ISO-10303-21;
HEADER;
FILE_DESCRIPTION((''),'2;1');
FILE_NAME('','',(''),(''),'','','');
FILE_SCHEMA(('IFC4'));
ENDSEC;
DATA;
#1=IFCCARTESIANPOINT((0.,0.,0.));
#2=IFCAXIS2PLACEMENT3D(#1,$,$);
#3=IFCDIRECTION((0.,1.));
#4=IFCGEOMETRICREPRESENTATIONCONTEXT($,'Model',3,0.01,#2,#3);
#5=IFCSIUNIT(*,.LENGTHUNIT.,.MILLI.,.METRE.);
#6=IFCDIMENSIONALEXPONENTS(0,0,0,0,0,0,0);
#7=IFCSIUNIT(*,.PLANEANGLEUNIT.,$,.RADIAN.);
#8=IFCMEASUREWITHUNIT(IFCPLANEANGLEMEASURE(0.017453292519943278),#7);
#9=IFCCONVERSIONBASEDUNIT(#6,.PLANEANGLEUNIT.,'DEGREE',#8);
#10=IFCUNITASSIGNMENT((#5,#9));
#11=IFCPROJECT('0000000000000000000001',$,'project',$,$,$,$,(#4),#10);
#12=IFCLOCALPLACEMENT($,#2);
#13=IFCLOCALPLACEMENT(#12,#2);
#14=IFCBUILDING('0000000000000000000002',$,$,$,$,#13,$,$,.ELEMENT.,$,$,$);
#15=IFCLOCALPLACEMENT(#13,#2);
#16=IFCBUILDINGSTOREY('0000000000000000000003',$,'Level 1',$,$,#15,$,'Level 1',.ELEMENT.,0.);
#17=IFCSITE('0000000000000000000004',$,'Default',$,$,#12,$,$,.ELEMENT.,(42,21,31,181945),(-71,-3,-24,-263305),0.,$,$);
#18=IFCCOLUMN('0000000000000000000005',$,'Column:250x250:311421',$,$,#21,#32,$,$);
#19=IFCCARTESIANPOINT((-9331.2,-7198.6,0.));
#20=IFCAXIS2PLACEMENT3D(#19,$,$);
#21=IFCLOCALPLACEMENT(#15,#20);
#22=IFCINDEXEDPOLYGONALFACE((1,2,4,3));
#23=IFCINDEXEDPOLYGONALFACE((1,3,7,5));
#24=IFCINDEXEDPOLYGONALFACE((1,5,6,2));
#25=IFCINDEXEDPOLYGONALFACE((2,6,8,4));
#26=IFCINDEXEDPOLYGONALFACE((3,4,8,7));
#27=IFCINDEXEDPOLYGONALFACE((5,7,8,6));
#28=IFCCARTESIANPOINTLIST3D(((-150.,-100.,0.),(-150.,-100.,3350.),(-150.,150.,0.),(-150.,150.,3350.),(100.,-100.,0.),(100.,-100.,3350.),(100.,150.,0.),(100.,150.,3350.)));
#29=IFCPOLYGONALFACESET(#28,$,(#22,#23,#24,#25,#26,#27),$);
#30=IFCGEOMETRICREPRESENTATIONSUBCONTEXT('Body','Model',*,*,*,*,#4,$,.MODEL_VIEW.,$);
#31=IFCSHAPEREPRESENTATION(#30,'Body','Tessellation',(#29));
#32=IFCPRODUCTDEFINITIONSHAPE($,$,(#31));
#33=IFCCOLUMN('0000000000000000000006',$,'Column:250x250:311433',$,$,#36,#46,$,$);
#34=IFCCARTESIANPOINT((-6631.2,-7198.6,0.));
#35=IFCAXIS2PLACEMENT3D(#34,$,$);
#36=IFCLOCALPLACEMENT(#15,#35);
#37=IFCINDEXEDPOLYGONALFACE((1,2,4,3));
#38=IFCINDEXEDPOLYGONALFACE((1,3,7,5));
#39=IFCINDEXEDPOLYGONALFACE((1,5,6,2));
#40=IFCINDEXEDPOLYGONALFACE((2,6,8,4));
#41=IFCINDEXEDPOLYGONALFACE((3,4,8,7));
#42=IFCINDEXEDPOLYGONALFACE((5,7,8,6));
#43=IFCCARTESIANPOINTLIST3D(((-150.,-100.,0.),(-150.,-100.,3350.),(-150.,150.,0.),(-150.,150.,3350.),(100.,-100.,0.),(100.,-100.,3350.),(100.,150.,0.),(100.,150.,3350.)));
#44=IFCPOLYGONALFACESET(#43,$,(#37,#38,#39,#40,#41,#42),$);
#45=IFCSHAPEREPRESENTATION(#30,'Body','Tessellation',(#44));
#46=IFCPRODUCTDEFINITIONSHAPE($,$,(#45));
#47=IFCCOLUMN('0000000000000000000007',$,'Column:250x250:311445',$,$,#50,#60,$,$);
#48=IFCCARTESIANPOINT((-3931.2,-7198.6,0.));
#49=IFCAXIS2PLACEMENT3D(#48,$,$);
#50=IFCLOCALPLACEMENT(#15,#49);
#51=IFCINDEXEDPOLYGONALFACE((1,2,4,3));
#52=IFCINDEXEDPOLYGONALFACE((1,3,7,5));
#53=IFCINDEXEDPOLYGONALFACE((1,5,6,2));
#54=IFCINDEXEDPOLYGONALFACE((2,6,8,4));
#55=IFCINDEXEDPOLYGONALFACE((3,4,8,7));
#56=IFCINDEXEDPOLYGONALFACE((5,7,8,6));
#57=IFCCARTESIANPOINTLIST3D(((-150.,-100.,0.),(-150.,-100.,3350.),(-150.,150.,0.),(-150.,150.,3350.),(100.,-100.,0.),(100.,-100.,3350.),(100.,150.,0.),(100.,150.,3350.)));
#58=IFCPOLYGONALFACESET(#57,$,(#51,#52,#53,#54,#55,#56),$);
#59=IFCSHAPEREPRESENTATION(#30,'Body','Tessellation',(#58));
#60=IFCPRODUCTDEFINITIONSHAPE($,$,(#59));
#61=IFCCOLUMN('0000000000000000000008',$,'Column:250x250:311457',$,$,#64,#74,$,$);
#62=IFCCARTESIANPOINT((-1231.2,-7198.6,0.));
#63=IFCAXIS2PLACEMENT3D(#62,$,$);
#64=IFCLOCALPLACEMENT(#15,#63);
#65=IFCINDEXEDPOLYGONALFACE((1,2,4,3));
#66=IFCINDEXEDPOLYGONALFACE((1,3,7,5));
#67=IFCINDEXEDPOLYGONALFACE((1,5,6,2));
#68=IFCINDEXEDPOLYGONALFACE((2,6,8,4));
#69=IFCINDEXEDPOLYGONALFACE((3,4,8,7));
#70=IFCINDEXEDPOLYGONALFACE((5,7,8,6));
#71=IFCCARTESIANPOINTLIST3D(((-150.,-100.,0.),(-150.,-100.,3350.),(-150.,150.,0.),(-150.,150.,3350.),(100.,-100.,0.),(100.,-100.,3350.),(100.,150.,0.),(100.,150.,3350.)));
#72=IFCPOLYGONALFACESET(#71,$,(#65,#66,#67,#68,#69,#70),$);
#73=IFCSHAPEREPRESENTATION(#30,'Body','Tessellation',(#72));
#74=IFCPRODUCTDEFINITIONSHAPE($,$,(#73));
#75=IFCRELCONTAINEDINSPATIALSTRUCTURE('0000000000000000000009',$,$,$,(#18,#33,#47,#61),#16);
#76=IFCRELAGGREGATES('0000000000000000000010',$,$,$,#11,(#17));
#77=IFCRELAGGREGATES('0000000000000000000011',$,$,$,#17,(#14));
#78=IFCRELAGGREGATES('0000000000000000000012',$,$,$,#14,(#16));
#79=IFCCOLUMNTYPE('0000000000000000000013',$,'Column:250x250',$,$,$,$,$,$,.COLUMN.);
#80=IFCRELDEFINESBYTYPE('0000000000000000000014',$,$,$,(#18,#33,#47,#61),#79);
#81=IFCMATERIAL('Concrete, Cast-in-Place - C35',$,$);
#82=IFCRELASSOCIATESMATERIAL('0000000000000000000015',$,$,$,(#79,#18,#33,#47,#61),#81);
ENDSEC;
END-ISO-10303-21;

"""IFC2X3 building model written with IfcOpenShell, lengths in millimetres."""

from ifc_helpers import new_model, entity, si_unit, converted_unit, direction, frame, origin, origin_2d_with_axis, place, context, subcontext, project, spatial, rectangle, extrude, source, transform, mapped, material, type_object, type_shapes, element, save


model = new_model("IFC2X3")

# Units and contexts
model_context = context("Model", 3, precision=0.01, world=origin(), true_north=direction((0.0, 1.0)))
body_context = subcontext(model_context, "Body", "Model", "MODEL_VIEW")
ifc_project = project(units=[si_unit("LENGTHUNIT", "METRE", prefix="MILLI"), converted_unit("PLANEANGLEUNIT", "DEGREE", entity("IfcPlaneAngleMeasure", 0.017453292519943278), si_unit("PLANEANGLEUNIT", "RADIAN"), dimensions=[0, 0, 0, 0, 0, 0, 0])], contexts=[model_context])

# Site, building, storey
site_placement = place(None, origin())
site = spatial("IfcSite", under=ifc_project, at=site_placement, Name="Default", CompositionType="ELEMENT", RefLatitude=(42, 21, 31, 181945), RefLongitude=(-71, -3, -24, -263305), RefElevation=0.0)
building_placement = place(site_placement, origin())
building = spatial("IfcBuilding", under=site, at=building_placement, CompositionType="ELEMENT")
storey_placement = place(building_placement, origin())
storey = spatial("IfcBuildingStorey", under=building, at=storey_placement, Name="Level 1", LongName="Level 1", CompositionType="ELEMENT", Elevation=0.0)

# Columns
ifc_material = material(Name="Concrete, Cast-in-Place - C35")
column_type_1 = type_object("IfcColumnType", Name="Column:250x250", PredefinedType="COLUMN", material=ifc_material)
shared_shape_1 = source(origin(), body_context, "Body", "SweptSolid", [
    extrude(rectangle(XDim=250.0, YDim=250.0, at=origin_2d_with_axis()), frame((-25.0, 25.0, 0.0), z_axis=(0.0, 0.0, 1.0), x_axis=(-1.0, 0.0, 0.0)), (0.0, 0.0, 1.0), 3350.0),
])
type_shapes(column_type_1, [shared_shape_1])
for number, where, name in (
    (1, (-9331.2, -7198.6, 0.0), "Column:250x250:311421"),
    (2, (-6631.2, -7198.6, 0.0), "Column:250x250:311433"),
    (3, (-3931.2, -7198.6, 0.0), "Column:250x250:311445"),
    (4, (-1231.2, -7198.6, 0.0), "Column:250x250:311457"),
):
    element("IfcColumn", number, at=place(storey_placement, frame(where)), inside=storey, type_object=column_type_1, material=ifc_material, Name=name, context=body_context, shape_type="MappedRepresentation", body=[
        mapped(shared_shape_1, transform((0.0, 0.0, 0.0), scale=1.0)),
    ])

save(model, "model.ifc")
